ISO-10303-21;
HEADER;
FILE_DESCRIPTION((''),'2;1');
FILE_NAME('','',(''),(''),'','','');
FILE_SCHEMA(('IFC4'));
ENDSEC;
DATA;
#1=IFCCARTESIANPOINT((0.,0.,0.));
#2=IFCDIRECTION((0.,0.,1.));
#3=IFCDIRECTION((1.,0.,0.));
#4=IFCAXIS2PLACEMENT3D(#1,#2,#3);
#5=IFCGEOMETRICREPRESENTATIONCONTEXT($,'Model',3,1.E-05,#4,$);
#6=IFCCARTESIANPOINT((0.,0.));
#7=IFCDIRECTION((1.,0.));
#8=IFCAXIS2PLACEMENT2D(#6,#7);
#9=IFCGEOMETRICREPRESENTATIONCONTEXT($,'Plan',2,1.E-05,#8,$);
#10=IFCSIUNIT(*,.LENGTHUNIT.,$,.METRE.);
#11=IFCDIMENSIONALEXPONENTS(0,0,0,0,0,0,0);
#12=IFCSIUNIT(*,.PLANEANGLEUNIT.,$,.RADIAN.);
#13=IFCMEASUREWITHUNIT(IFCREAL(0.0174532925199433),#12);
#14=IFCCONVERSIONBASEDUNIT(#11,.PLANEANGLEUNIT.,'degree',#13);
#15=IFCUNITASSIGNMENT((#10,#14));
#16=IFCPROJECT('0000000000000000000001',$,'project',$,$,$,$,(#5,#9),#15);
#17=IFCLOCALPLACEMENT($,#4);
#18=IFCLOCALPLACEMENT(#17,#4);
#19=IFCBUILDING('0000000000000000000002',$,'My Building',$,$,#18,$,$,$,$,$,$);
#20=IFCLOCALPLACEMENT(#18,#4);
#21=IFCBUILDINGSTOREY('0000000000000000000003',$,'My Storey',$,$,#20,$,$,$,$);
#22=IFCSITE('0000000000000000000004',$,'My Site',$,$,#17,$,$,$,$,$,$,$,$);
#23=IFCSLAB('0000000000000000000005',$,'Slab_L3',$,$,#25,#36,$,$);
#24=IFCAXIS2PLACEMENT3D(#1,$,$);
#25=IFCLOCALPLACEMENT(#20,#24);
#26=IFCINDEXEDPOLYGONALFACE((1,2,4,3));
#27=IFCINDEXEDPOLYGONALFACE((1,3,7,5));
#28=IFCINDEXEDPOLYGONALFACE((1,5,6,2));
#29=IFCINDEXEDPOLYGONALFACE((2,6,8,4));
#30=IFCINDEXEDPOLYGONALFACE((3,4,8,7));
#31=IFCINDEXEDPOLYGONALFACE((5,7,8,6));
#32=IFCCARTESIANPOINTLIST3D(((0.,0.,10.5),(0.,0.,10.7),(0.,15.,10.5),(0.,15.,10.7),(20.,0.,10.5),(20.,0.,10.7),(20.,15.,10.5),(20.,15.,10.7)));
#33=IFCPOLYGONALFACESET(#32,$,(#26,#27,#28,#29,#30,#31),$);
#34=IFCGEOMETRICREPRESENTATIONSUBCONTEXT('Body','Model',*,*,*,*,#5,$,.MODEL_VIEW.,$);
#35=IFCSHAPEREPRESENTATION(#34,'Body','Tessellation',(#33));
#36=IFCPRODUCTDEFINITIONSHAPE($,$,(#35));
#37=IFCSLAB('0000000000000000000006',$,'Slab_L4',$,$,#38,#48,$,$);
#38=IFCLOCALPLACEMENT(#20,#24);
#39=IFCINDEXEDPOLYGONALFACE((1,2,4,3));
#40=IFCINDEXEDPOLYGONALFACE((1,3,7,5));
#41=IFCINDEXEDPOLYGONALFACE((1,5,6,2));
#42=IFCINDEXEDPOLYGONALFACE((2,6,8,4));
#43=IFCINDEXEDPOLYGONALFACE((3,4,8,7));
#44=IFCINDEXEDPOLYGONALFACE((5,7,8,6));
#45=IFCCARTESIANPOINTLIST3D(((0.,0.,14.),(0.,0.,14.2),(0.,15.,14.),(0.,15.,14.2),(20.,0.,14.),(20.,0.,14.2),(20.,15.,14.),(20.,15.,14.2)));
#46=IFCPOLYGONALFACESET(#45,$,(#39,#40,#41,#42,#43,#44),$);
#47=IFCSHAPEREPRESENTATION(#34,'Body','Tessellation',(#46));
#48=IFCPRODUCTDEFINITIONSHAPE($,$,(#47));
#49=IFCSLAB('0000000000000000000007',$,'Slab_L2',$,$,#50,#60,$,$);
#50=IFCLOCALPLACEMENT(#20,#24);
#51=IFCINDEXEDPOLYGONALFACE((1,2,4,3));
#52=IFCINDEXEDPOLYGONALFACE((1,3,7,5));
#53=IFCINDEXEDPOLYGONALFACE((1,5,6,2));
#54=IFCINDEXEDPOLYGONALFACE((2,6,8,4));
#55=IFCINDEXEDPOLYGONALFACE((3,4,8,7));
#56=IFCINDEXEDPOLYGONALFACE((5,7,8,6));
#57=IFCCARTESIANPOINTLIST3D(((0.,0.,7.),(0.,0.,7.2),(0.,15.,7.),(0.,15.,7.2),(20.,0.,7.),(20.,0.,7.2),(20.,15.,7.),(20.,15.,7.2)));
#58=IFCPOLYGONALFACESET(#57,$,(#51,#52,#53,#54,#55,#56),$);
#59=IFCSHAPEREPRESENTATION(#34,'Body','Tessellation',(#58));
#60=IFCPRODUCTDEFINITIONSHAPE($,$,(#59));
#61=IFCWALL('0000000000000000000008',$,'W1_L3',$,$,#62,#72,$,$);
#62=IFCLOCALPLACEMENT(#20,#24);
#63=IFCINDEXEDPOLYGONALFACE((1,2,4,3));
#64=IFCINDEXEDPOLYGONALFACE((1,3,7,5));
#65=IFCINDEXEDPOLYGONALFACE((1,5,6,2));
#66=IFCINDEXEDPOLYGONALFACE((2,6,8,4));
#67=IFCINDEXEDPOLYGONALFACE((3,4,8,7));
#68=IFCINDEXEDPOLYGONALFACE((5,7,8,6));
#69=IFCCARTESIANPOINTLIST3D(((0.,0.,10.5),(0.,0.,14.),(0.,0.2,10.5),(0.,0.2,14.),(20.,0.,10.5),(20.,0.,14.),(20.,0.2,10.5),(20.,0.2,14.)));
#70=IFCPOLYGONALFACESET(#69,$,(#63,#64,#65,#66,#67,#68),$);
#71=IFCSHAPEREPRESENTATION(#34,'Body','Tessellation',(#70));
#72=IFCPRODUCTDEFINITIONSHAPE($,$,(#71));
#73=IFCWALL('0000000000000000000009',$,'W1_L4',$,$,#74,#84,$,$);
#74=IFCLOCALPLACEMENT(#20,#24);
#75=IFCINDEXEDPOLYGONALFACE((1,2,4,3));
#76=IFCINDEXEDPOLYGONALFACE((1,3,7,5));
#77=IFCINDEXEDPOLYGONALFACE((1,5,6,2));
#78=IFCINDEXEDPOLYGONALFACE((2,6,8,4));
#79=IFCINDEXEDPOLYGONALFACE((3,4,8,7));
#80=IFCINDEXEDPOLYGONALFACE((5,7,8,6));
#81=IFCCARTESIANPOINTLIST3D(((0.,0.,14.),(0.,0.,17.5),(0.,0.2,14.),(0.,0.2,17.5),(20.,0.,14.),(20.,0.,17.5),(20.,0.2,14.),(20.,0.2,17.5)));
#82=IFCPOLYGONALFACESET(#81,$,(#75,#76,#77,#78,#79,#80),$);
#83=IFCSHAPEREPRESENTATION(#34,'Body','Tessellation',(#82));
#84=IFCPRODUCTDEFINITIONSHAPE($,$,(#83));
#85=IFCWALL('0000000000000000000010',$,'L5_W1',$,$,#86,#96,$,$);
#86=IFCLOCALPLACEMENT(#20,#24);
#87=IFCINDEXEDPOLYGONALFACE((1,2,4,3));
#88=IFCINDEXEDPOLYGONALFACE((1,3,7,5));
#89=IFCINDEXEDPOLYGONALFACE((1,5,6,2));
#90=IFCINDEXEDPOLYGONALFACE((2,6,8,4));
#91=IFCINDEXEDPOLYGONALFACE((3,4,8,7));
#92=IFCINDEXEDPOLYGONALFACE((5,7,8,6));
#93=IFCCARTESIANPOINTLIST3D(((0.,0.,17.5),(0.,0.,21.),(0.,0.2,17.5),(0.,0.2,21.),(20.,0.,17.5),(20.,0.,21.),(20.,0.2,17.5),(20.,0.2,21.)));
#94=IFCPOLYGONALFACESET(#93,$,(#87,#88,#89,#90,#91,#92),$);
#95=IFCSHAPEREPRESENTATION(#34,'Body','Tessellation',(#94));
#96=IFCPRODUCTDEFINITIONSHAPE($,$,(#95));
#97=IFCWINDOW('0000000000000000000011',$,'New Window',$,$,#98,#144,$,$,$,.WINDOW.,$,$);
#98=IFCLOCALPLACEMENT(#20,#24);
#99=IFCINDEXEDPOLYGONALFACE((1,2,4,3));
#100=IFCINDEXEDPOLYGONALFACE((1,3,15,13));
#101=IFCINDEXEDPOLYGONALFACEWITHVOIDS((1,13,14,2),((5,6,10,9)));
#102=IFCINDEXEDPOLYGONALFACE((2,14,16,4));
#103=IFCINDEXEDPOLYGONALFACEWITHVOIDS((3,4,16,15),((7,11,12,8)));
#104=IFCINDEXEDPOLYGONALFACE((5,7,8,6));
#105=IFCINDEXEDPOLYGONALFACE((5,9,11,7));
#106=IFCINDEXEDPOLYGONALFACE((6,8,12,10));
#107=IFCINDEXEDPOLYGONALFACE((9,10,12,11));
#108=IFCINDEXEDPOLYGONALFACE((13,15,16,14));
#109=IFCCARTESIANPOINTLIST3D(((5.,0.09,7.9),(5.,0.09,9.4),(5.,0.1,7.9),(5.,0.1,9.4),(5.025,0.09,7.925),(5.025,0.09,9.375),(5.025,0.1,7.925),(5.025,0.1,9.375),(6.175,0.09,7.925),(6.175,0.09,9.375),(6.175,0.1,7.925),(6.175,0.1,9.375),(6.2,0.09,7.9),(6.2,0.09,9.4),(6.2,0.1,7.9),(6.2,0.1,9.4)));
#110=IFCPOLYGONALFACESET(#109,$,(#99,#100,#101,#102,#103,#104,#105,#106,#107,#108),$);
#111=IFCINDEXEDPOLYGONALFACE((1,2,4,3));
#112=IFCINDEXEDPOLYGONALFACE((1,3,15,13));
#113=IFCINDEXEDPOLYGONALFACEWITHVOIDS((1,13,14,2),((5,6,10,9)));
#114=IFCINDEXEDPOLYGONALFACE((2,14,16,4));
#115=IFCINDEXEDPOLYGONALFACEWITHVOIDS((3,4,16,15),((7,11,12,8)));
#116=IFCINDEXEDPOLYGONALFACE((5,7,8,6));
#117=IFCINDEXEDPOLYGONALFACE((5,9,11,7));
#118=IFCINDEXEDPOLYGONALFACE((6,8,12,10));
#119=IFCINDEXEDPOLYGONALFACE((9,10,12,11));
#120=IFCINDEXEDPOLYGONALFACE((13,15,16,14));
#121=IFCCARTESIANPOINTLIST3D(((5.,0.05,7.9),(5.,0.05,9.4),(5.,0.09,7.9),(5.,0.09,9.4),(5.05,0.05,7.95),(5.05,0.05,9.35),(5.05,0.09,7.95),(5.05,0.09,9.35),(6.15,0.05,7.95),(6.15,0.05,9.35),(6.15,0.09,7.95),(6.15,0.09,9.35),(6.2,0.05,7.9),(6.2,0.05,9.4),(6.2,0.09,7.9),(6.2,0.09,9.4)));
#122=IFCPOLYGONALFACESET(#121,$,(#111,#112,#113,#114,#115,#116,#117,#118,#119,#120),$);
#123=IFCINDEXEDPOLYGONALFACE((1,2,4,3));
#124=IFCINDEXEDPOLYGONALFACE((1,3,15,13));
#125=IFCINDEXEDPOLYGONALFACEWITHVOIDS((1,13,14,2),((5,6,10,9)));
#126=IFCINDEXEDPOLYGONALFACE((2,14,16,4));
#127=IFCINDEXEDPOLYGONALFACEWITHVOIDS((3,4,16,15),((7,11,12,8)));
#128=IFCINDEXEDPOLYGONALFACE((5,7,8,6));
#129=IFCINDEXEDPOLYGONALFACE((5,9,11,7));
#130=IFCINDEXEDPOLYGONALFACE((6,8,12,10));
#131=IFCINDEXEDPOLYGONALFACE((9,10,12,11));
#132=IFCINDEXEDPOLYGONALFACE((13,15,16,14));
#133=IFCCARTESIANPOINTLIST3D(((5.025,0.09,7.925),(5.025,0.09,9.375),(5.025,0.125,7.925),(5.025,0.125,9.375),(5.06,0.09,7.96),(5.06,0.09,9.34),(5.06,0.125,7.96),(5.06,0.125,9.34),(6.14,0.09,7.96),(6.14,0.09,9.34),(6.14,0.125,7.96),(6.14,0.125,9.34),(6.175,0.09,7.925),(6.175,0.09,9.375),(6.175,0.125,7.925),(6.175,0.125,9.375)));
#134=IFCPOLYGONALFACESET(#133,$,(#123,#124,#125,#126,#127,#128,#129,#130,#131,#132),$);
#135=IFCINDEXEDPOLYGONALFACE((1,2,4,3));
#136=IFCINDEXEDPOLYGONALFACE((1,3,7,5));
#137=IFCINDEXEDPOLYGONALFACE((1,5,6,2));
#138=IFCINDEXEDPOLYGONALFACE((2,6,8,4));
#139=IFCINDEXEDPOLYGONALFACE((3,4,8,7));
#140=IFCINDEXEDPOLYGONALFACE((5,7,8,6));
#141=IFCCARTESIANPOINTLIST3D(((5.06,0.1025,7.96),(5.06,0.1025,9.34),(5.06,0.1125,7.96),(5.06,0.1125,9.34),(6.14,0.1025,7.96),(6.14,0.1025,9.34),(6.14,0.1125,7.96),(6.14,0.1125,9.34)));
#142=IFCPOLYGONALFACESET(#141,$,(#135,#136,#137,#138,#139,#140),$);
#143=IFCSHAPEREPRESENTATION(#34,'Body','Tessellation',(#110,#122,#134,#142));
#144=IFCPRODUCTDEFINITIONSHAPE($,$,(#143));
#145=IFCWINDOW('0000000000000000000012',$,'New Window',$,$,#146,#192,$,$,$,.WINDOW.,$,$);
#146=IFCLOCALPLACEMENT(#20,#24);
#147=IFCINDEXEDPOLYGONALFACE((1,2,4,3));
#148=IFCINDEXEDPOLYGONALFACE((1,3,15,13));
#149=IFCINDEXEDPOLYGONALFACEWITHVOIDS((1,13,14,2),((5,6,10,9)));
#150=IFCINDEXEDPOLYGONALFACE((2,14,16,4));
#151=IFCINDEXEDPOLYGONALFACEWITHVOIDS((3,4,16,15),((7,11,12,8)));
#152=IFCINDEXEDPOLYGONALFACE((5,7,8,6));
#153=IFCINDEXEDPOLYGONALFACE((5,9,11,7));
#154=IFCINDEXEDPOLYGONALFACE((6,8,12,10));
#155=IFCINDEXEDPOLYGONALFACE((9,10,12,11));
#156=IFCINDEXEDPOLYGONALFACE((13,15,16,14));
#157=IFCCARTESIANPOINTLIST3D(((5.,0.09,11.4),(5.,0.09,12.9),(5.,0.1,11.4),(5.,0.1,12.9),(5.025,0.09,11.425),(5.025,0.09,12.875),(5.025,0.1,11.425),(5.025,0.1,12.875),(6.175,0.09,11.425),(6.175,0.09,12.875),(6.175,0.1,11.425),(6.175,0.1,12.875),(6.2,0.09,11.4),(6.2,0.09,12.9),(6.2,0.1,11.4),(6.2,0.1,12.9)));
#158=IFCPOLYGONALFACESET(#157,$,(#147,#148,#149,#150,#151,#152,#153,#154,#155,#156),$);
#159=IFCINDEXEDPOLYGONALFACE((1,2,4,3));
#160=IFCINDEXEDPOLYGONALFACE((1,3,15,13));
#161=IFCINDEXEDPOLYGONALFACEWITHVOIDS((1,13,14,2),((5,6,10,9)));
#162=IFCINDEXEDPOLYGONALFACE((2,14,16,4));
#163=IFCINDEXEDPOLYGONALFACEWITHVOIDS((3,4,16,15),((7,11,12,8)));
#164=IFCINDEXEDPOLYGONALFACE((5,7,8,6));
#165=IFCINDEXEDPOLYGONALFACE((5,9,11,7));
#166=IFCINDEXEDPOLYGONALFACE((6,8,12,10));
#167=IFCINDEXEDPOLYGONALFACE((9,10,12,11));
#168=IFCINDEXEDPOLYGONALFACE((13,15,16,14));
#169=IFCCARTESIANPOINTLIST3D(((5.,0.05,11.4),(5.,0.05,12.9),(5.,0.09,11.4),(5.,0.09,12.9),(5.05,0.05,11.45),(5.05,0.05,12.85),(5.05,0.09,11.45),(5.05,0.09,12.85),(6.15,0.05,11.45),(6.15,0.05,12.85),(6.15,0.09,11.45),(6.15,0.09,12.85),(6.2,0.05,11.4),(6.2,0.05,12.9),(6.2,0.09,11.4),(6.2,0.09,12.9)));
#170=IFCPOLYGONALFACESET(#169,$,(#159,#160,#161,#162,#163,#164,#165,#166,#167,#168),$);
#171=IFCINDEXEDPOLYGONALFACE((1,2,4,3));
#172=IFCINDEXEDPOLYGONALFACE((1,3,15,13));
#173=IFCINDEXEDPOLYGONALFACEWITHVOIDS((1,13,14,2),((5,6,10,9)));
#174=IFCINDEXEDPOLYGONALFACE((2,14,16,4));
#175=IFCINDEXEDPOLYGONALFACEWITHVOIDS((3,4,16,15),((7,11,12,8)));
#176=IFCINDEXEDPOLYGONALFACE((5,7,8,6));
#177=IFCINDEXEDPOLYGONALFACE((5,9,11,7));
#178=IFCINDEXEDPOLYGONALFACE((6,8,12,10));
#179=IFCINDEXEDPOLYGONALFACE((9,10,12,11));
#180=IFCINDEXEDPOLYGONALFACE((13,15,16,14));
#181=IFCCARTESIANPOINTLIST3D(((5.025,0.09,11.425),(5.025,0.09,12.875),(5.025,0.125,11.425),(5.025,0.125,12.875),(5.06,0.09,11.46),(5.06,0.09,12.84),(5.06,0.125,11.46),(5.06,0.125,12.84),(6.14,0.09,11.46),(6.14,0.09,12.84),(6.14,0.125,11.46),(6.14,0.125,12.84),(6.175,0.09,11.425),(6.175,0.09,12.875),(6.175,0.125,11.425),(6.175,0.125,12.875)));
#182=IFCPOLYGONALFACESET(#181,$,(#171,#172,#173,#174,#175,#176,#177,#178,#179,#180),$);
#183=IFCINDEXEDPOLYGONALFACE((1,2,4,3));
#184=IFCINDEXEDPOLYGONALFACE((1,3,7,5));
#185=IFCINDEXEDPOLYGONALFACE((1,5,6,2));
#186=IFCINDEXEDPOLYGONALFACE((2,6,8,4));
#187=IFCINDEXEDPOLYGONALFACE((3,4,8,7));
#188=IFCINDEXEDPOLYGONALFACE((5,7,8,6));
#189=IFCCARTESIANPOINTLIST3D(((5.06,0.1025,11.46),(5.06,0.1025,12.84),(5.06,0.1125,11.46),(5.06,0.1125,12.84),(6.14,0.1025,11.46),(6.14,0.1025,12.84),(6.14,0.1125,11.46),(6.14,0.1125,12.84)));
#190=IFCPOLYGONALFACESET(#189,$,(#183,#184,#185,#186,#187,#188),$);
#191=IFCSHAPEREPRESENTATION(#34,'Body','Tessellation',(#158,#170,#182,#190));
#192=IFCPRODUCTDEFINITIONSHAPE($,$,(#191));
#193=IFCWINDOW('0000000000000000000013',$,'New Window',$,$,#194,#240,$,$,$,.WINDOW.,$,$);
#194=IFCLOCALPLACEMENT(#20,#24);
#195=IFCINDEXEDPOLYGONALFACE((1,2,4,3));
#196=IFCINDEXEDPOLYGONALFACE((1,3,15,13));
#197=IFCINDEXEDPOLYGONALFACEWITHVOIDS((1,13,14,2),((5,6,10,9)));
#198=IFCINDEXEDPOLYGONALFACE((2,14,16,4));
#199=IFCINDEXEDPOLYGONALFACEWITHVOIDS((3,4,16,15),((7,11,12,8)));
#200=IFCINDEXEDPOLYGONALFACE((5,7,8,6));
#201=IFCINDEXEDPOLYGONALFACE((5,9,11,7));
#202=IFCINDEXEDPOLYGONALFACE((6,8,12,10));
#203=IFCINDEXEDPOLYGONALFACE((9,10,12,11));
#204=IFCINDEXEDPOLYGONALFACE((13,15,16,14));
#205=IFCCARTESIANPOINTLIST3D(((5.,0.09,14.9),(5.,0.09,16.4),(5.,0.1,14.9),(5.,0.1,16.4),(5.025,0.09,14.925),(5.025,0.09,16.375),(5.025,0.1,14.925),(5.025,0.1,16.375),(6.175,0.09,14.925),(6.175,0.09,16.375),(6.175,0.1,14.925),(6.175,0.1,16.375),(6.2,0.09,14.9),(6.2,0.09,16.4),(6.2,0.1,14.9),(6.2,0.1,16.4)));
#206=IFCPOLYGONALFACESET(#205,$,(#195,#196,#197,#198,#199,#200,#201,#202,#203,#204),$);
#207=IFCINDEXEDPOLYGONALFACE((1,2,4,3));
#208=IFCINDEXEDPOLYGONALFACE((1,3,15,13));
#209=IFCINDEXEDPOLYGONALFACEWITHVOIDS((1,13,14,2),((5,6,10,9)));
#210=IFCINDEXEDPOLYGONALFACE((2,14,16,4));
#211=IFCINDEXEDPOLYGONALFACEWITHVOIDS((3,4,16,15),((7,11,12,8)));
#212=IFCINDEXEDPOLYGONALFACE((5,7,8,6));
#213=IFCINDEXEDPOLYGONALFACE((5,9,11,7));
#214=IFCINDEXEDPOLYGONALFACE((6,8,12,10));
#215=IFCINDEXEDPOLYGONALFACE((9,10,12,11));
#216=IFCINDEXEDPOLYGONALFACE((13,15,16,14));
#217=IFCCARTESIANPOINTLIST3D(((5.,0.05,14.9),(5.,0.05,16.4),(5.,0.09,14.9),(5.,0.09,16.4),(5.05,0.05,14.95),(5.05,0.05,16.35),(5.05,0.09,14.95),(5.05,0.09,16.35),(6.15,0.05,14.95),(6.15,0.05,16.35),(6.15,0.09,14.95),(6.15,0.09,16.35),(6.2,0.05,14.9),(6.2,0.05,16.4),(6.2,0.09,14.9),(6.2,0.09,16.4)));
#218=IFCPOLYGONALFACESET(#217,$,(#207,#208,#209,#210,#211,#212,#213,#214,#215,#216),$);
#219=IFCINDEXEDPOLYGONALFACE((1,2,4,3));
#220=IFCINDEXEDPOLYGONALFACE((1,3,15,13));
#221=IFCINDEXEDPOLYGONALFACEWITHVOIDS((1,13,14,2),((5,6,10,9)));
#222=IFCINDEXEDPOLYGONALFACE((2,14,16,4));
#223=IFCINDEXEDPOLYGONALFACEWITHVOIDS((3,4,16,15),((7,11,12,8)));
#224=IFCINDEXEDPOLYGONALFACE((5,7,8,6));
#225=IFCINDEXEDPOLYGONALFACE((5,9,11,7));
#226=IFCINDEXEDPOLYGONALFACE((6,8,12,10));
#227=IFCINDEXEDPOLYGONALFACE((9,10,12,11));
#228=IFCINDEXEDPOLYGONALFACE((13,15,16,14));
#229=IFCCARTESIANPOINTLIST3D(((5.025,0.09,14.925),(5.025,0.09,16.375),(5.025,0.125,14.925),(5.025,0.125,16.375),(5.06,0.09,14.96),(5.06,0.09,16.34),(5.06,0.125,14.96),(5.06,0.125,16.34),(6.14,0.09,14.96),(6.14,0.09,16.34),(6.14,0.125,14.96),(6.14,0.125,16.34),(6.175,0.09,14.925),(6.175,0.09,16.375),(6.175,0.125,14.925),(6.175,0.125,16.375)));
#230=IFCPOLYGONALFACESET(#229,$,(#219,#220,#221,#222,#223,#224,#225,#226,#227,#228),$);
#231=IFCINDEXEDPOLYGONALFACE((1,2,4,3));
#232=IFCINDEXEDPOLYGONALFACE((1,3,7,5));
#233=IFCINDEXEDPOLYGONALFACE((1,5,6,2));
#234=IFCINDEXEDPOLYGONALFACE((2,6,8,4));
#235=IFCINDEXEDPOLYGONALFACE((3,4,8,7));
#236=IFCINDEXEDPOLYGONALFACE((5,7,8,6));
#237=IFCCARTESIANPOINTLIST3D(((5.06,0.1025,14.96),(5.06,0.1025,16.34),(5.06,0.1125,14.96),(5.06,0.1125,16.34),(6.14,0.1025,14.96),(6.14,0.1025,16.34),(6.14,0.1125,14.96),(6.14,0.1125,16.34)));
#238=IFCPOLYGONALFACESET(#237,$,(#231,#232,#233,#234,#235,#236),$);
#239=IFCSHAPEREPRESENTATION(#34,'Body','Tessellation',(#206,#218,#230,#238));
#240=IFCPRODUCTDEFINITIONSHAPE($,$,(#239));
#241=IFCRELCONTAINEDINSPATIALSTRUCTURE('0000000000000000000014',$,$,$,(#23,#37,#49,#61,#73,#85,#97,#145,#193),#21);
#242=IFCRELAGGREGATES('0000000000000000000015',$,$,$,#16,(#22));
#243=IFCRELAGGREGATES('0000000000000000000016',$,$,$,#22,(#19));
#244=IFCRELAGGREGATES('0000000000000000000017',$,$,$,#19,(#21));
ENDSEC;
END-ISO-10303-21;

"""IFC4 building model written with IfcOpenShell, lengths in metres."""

from ifc_helpers import new_model, entity, si_unit, converted_unit, frame, origin_with_axes, origin_2d_with_axis, place, context, subcontext, project, spatial, line, indexed_curve, outline, extrude, element, save


model = new_model("IFC4")

# Units and contexts
model_context = context("Model", 3, precision=1e-05, world=origin_with_axes())
plan_context = context("Plan", 2, precision=1e-05, world=origin_2d_with_axis())
body_context = subcontext(model_context, "Body", "Model", "MODEL_VIEW")
ifc_project = project(units=[si_unit("LENGTHUNIT", "METRE"), converted_unit("PLANEANGLEUNIT", "degree", entity("IfcReal", 0.0174532925199433), si_unit("PLANEANGLEUNIT", "RADIAN"), dimensions=[0, 0, 0, 0, 0, 0, 0])], contexts=[model_context, plan_context])

# Site, building, storey
site_placement = place(None, origin_with_axes())
site = spatial("IfcSite", under=ifc_project, at=site_placement, Name="My Site")
building_placement = place(site_placement, origin_with_axes())
building = spatial("IfcBuilding", under=site, at=building_placement, Name="My Building")
storey_placement = place(building_placement, origin_with_axes())
storey = spatial("IfcBuildingStorey", under=building, at=storey_placement, Name="My Storey")

# Slabs
for number, where, z_axis, x_axis, name in (
    (1, (0.0, 0.0, 10.5), (0.0, 0.0, 1.0), (1.0, 0.0, 0.0), "Slab_L3"),
    (2, (0.0, 0.0, 14.0), (0.0, 0.0, 1.0), (1.0, 0.0, 0.0), "Slab_L4"),
    (3, (0.0, 0.0, 7.0), (0.0, 0.0, 1.0), (1.0, 0.0, 0.0), "Slab_L2"),
):
    element("IfcSlab", number, at=place(storey_placement, frame(where, z_axis=z_axis, x_axis=x_axis)), inside=storey, Name=name, context=body_context, shape_type="SweptSolid", body=[
        extrude(outline(indexed_curve([(0.0, 0.0), (20.0, 0.0), (20.0, 15.0), (0.0, 15.0), (0.0, 0.0)])), None, (0.0, 0.0, 1.0), 0.2),
    ])

# Walls
for number, where, z_axis, x_axis, name in (
    (4, (0.0, 0.0, 10.5), (0.0, 0.0, 1.0), (1.0, 0.0, 0.0), "W1_L3"),
    (5, (0.0, 0.0, 14.0), (0.0, 0.0, 1.0), (1.0, 0.0, 0.0), "W1_L4"),
    (6, (0.0, 0.0, 17.5), (0.0, 0.0, 1.0), (1.0, 0.0, 0.0), "L5_W1"),
):
    element("IfcWall", number, at=place(storey_placement, frame(where, z_axis=z_axis, x_axis=x_axis)), inside=storey, Name=name, context=body_context, shape_type="SweptSolid", body=[
        extrude(outline(indexed_curve([(0.0, 0.0), (0.0, 0.2), (20.0, 0.2), (20.0, 0.0), (0.0, 0.0)], self_intersect=False)), origin_with_axes(), (0.0, 0.0, 1.0), 3.5),
    ])

# Windows
for number, where, z_axis, x_axis, name in (
    (7, (5.0, 0.0, 7.9), (0.0, 0.0, 1.0), (1.0, 0.0, 0.0), "New Window"),
    (8, (5.0, 0.0, 11.4), (0.0, 0.0, 1.0), (1.0, 0.0, 0.0), "New Window"),
    (9, (5.0, 0.0, 14.9), (0.0, 0.0, 1.0), (1.0, 0.0, 0.0), "New Window"),
):
    element("IfcWindow", number, at=place(storey_placement, frame(where, z_axis=z_axis, x_axis=x_axis)), inside=storey, Name=name, PredefinedType="WINDOW", context=body_context, shape_type="SweptSolid", body=[
        extrude(outline(indexed_curve([(0.0, 0.0), (1.2, 0.0), (1.2, 1.5), (0.0, 1.5)], segments=[line(1, 2, 3, 4, 1)]), holes=[indexed_curve([(0.025, 0.025), (1.175, 0.025), (1.175, 1.475), (0.025, 1.475)], segments=[line(1, 2, 3, 4, 1)])]), frame((0.0, 0.09, 0.0), z_axis=(0.0, -1.0, 0.0), x_axis=(1.0, 0.0, 0.0)), (0.0, 0.0, -1.0), 0.01),
        extrude(outline(indexed_curve([(0.0, 0.0), (1.2, 0.0), (1.2, 1.5), (0.0, 1.5)], segments=[line(1, 2, 3, 4, 1)]), holes=[indexed_curve([(0.05, 0.05), (1.15, 0.05), (1.15, 1.45), (0.05, 1.45)], segments=[line(1, 2, 3, 4, 1)])]), frame((0.0, 0.05, 0.0), z_axis=(0.0, -1.0, 0.0), x_axis=(1.0, 0.0, 0.0)), (0.0, 0.0, -1.0), 0.04),
        extrude(outline(indexed_curve([(0.0, 0.0), (1.15, 0.0), (1.15, 1.45), (0.0, 1.45)], segments=[line(1, 2, 3, 4, 1)]), holes=[indexed_curve([(0.035, 0.035), (1.115, 0.035), (1.115, 1.415), (0.035, 1.415)], segments=[line(1, 2, 3, 4, 1)])]), frame((0.025, 0.09, 0.025), z_axis=(0.0, -1.0, 0.0), x_axis=(1.0, 0.0, 0.0)), (0.0, 0.0, -1.0), 0.035),
        extrude(outline(indexed_curve([(0.035, 0.035), (1.115, 0.035), (1.115, 1.415), (0.035, 1.415)], segments=[line(1, 2, 3, 4, 1)])), frame((0.025, 0.1025, 0.025), z_axis=(0.0, -1.0, 0.0), x_axis=(1.0, 0.0, 0.0)), (0.0, 0.0, -1.0), 0.01),
    ])

save(model, "model.ifc")
